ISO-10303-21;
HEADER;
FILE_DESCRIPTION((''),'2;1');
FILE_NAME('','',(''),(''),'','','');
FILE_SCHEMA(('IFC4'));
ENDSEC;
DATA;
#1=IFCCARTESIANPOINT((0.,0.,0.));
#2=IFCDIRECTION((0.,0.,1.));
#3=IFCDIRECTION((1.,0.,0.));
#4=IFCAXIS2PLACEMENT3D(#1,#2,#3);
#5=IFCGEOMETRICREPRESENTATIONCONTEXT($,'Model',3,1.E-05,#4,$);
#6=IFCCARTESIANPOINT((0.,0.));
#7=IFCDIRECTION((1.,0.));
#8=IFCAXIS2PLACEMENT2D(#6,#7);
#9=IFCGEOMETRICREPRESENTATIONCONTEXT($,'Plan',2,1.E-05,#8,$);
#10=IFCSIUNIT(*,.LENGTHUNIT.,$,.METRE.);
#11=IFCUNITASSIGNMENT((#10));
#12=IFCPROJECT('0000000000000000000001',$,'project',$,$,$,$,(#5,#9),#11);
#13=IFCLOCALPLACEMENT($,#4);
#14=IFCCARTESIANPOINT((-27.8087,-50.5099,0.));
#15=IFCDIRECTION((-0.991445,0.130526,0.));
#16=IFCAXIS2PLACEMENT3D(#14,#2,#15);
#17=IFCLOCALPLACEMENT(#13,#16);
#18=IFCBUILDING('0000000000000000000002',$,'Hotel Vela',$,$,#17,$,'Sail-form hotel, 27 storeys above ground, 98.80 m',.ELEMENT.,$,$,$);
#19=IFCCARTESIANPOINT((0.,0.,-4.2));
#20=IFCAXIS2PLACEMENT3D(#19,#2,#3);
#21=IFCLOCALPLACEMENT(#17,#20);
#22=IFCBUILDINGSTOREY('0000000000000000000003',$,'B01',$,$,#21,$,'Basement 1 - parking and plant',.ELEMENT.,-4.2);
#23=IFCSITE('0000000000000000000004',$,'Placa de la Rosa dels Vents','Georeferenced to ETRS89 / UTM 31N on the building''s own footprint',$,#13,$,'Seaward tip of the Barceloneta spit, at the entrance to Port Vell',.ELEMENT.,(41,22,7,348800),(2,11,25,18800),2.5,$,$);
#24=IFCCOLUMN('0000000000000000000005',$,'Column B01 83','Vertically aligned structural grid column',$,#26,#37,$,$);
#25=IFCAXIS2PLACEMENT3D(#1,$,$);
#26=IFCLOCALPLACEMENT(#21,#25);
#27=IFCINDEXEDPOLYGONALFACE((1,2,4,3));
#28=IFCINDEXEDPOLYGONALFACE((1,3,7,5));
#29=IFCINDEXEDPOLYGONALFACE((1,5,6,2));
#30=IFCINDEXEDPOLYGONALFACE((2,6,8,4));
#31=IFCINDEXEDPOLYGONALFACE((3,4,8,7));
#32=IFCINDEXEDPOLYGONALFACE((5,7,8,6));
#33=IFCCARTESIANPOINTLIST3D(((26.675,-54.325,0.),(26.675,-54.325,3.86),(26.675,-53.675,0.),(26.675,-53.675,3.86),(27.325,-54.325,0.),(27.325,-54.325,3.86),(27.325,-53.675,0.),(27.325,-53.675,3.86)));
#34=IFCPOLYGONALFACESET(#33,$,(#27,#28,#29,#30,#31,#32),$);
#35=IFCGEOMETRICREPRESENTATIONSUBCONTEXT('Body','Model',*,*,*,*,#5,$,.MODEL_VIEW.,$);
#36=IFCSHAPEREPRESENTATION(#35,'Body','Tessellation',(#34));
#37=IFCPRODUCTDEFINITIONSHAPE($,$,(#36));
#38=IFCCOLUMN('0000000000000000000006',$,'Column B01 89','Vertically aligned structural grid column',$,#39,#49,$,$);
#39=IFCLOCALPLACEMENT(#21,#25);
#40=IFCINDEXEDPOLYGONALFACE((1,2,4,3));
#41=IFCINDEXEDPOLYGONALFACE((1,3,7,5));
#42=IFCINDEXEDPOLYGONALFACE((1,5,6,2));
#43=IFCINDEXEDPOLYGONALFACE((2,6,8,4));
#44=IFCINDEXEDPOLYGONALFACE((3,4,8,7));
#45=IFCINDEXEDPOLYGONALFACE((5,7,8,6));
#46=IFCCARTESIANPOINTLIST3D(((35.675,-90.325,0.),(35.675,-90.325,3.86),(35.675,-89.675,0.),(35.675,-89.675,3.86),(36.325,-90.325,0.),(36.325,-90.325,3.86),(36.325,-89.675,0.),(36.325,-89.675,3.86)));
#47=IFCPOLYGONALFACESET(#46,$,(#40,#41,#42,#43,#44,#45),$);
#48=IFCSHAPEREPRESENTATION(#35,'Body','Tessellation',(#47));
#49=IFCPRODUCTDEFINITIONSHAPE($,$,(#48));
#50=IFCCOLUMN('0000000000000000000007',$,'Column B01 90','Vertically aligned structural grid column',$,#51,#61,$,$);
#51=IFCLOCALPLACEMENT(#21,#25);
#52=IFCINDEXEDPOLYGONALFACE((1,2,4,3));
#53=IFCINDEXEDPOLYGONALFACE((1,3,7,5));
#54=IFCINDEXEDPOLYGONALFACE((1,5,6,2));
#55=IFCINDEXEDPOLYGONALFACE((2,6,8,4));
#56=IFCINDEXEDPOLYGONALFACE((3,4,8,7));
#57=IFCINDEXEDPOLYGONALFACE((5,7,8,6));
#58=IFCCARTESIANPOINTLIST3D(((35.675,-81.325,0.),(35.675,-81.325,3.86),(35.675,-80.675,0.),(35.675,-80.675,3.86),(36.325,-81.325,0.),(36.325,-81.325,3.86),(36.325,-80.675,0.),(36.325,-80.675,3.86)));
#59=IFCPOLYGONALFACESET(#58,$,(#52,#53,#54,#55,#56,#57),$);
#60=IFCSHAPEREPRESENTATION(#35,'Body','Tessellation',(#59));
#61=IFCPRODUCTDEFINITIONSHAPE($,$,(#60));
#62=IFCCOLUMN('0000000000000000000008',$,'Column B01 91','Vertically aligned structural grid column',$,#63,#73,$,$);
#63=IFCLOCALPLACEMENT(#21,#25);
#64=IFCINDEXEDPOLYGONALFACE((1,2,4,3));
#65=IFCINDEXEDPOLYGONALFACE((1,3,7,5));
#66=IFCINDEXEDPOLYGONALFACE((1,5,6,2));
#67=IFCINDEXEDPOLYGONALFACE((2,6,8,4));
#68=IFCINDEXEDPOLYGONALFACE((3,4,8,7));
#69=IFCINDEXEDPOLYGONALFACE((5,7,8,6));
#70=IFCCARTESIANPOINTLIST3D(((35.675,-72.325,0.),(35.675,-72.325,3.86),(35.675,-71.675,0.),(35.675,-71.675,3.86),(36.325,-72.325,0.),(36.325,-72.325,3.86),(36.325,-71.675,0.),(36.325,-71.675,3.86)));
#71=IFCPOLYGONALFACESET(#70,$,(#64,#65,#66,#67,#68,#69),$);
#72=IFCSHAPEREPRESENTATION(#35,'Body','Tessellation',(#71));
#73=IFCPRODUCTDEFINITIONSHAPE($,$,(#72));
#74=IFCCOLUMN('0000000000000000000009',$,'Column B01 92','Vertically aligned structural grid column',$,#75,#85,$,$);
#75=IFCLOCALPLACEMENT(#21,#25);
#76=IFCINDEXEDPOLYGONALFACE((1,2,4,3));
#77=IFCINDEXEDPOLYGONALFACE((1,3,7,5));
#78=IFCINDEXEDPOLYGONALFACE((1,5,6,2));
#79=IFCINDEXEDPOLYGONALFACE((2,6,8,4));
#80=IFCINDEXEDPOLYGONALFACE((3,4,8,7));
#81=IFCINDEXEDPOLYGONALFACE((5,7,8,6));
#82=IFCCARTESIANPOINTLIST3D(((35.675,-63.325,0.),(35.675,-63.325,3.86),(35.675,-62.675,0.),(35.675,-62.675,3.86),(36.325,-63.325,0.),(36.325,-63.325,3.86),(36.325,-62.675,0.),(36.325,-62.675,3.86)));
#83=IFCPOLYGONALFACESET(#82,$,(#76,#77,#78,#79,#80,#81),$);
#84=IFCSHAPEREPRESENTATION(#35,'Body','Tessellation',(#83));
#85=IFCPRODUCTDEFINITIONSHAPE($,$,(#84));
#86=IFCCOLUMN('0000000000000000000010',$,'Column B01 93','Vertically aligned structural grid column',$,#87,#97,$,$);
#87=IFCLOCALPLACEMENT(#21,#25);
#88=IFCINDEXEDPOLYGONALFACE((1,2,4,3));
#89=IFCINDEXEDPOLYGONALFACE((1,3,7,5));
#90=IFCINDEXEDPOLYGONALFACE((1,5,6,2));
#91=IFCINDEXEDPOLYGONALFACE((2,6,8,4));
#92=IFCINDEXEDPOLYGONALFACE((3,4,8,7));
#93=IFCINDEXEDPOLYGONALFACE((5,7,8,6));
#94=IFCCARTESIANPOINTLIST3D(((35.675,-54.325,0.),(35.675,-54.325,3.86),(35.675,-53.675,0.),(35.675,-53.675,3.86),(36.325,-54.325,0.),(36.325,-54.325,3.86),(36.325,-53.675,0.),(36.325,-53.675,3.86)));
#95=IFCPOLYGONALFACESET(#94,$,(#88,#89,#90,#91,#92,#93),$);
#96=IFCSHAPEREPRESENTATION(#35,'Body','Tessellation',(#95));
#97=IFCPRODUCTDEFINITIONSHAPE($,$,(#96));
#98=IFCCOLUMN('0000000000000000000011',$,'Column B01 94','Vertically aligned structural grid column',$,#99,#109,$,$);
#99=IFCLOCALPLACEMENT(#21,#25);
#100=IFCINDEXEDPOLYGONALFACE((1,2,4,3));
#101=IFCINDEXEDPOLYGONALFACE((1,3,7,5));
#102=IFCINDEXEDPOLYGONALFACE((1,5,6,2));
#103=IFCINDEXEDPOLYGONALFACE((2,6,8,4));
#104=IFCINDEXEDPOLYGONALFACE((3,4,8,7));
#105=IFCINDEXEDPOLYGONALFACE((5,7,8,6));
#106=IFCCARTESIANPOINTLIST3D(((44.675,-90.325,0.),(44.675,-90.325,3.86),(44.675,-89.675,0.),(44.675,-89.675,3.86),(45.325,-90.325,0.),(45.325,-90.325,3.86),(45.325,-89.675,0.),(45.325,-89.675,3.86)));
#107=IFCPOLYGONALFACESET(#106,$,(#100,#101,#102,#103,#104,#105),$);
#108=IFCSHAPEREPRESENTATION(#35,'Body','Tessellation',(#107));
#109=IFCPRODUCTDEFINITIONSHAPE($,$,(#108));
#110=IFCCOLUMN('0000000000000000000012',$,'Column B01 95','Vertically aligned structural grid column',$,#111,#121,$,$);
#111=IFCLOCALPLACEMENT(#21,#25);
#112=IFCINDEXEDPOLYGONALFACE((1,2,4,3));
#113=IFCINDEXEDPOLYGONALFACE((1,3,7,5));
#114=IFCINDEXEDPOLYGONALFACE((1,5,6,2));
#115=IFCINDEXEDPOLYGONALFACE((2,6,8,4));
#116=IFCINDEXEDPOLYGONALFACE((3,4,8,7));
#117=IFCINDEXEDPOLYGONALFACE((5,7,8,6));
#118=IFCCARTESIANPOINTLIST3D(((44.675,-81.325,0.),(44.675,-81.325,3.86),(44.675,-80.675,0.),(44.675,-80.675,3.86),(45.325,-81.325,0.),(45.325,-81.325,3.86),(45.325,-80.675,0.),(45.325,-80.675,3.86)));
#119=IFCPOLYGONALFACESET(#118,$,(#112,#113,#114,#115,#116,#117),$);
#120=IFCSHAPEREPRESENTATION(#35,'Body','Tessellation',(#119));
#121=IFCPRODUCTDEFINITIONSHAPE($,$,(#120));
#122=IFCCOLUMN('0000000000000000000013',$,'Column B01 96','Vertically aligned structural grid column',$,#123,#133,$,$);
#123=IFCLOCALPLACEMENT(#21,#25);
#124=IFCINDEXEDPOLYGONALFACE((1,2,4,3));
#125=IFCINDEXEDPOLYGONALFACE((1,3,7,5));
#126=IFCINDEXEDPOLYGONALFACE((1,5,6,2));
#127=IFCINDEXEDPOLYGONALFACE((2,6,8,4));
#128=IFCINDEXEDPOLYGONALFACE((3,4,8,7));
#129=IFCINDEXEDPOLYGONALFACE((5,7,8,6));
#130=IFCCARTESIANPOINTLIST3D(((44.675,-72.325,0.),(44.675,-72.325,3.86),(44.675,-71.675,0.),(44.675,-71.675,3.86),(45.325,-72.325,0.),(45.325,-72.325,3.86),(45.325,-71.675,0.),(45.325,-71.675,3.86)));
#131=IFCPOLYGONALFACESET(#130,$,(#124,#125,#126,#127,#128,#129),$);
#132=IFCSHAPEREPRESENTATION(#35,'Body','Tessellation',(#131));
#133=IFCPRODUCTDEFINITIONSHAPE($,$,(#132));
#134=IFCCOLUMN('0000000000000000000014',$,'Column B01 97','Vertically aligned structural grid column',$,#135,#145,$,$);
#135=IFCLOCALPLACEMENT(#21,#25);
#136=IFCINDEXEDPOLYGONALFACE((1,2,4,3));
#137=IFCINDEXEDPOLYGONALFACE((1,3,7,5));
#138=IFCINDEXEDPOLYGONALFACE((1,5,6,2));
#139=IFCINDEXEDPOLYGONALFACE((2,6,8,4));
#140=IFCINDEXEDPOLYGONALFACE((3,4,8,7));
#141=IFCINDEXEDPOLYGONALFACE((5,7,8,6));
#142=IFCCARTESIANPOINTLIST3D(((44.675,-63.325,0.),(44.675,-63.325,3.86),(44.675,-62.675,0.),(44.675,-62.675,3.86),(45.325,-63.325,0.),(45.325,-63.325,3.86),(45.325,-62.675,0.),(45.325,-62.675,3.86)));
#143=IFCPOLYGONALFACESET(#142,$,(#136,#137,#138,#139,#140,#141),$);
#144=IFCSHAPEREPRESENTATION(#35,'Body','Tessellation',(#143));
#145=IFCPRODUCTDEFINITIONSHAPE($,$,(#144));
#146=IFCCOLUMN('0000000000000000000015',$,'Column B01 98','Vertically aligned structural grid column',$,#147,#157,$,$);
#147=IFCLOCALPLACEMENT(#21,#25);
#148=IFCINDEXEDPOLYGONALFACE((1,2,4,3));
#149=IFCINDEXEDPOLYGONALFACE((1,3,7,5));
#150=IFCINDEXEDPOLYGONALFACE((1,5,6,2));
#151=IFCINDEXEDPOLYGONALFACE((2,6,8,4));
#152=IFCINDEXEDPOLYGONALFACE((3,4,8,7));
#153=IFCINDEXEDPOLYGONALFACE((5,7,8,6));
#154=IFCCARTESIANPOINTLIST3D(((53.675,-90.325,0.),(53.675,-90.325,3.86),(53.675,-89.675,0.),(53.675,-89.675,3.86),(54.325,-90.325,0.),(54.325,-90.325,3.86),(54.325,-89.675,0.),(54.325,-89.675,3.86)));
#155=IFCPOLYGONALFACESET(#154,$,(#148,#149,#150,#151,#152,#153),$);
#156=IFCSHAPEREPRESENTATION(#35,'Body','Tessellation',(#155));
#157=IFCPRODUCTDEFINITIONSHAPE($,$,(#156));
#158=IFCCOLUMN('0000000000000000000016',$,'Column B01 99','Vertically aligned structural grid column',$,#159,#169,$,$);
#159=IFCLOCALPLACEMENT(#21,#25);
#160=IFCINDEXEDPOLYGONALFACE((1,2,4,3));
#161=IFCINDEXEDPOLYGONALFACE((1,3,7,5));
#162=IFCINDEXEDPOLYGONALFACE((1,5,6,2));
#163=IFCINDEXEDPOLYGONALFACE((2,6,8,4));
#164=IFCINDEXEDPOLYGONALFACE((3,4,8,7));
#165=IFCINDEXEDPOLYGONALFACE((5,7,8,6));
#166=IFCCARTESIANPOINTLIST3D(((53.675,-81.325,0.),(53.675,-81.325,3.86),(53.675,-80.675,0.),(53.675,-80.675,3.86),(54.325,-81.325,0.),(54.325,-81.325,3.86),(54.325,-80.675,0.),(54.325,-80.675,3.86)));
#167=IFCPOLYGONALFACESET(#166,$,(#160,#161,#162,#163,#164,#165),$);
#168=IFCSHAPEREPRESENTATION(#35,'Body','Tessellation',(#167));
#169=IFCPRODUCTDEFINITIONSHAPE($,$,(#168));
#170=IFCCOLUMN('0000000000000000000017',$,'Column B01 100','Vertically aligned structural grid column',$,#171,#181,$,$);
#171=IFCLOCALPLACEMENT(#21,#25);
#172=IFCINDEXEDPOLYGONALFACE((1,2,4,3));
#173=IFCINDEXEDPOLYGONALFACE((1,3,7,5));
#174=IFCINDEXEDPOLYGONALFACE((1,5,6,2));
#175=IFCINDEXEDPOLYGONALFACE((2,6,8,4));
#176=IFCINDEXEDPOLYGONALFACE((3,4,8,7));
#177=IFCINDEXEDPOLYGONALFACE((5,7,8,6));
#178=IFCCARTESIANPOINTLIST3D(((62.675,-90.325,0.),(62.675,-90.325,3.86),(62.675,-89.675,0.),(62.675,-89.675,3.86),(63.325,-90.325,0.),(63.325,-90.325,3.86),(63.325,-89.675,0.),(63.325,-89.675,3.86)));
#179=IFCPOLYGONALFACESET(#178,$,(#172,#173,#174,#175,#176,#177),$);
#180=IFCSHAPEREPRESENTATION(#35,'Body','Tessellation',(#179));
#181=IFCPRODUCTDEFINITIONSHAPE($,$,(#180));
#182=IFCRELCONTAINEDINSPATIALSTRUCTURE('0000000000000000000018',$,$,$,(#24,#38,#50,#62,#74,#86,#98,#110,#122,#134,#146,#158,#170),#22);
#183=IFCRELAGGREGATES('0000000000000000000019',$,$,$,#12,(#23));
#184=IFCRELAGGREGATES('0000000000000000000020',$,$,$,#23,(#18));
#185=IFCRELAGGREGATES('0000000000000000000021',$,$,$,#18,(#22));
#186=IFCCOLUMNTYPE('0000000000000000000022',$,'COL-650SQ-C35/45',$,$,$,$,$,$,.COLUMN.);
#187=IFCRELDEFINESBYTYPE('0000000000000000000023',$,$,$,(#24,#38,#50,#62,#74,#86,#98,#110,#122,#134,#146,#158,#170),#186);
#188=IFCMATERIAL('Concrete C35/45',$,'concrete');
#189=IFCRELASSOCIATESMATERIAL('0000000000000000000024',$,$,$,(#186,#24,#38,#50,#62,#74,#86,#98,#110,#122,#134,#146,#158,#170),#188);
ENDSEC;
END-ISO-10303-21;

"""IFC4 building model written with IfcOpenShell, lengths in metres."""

from ifc_helpers import new_model, si_unit, frame, origin_with_axes, origin_2d_with_axis, place, context, subcontext, project, spatial, line, indexed_curve, rectangle, outline, extrude, material, material_profile, profile_set, profile_usage, type_object, element, save


model = new_model("IFC4")

# Units and contexts
model_context = context("Model", 3, precision=1e-05, world=origin_with_axes())
plan_context = context("Plan", 2, precision=1e-05, world=origin_2d_with_axis())
body_context = subcontext(model_context, "Body", "Model", "MODEL_VIEW")
ifc_project = project(units=[si_unit("LENGTHUNIT", "METRE")], contexts=[model_context, plan_context])

# Site, building, storey
site_placement = place(None, origin_with_axes())
site = spatial("IfcSite", under=ifc_project, at=site_placement, Name="Placa de la Rosa dels Vents", Description="Georeferenced to ETRS89 / UTM 31N on the building's own footprint", LongName="Seaward tip of the Barceloneta spit, at the entrance to Port Vell", CompositionType="ELEMENT", RefLatitude=(41, 22, 7, 348800), RefLongitude=(2, 11, 25, 18800), RefElevation=2.5)
building_placement = place(site_placement, frame((-27.8087, -50.5099, 0.0), z_axis=(0.0, 0.0, 1.0), x_axis=(-0.991445, 0.130526, 0.0)))
building = spatial("IfcBuilding", under=site, at=building_placement, Name="Hotel Vela", LongName="Sail-form hotel, 27 storeys above ground, 98.80 m", CompositionType="ELEMENT")
storey_placement = place(building_placement, frame((0.0, 0.0, -4.2), z_axis=(0.0, 0.0, 1.0), x_axis=(1.0, 0.0, 0.0)))
storey = spatial("IfcBuildingStorey", under=building, at=storey_placement, Name="B01", LongName="Basement 1 - parking and plant", CompositionType="ELEMENT", Elevation=-4.2)

# Columns
ifc_material = material(Name="Concrete C35/45", Category="concrete")
ifc_material_profile = material_profile(ifc_material, rectangle(XDim=0.65, YDim=0.65))
ifc_profile_set = profile_set([ifc_material_profile], Name="COL-650SQ-C35/45")
column_type = type_object("IfcColumnType", Name="COL-650SQ-C35/45", PredefinedType="COLUMN", material=ifc_profile_set)
ifc_profile_usage_1 = profile_usage(ifc_profile_set)
column_1_placement = place(storey_placement, frame((26.675, -54.325, 0.0), z_axis=(0.0, 0.0, 1.0), x_axis=(1.0, 0.0, 0.0)))
element("IfcColumn", 1, at=column_1_placement, inside=storey, type_object=column_type, material=ifc_profile_usage_1, Name="Column B01 83", Description="Vertically aligned structural grid column", context=body_context, shape_type="SweptSolid", body=[
    extrude(outline(indexed_curve([(0.0, 0.0), (0.65, 0.0), (0.65, 0.65), (0.0, 0.65)], segments=[line(1, 2, 3, 4, 1)])), origin_with_axes(), (0.0, 0.0, 1.0), 3.86),
])
ifc_profile_usage_2 = profile_usage(ifc_profile_set)
column_2_placement = place(storey_placement, frame((35.675, -90.325, 0.0), z_axis=(0.0, 0.0, 1.0), x_axis=(1.0, 0.0, 0.0)))
element("IfcColumn", 2, at=column_2_placement, inside=storey, type_object=column_type, material=ifc_profile_usage_2, Name="Column B01 89", Description="Vertically aligned structural grid column", context=body_context, shape_type="SweptSolid", body=[
    extrude(outline(indexed_curve([(0.0, 0.0), (0.65, 0.0), (0.65, 0.65), (0.0, 0.65)], segments=[line(1, 2, 3, 4, 1)])), origin_with_axes(), (0.0, 0.0, 1.0), 3.86),
])
ifc_profile_usage_3 = profile_usage(ifc_profile_set)
column_3_placement = place(storey_placement, frame((35.675, -81.325, 0.0), z_axis=(0.0, 0.0, 1.0), x_axis=(1.0, 0.0, 0.0)))
element("IfcColumn", 3, at=column_3_placement, inside=storey, type_object=column_type, material=ifc_profile_usage_3, Name="Column B01 90", Description="Vertically aligned structural grid column", context=body_context, shape_type="SweptSolid", body=[
    extrude(outline(indexed_curve([(0.0, 0.0), (0.65, 0.0), (0.65, 0.65), (0.0, 0.65)], segments=[line(1, 2, 3, 4, 1)])), origin_with_axes(), (0.0, 0.0, 1.0), 3.86),
])
ifc_profile_usage_4 = profile_usage(ifc_profile_set)
column_4_placement = place(storey_placement, frame((35.675, -72.325, 0.0), z_axis=(0.0, 0.0, 1.0), x_axis=(1.0, 0.0, 0.0)))
element("IfcColumn", 4, at=column_4_placement, inside=storey, type_object=column_type, material=ifc_profile_usage_4, Name="Column B01 91", Description="Vertically aligned structural grid column", context=body_context, shape_type="SweptSolid", body=[
    extrude(outline(indexed_curve([(0.0, 0.0), (0.65, 0.0), (0.65, 0.65), (0.0, 0.65)], segments=[line(1, 2, 3, 4, 1)])), origin_with_axes(), (0.0, 0.0, 1.0), 3.86),
])
ifc_profile_usage_5 = profile_usage(ifc_profile_set)
column_5_placement = place(storey_placement, frame((35.675, -63.325, 0.0), z_axis=(0.0, 0.0, 1.0), x_axis=(1.0, 0.0, 0.0)))
element("IfcColumn", 5, at=column_5_placement, inside=storey, type_object=column_type, material=ifc_profile_usage_5, Name="Column B01 92", Description="Vertically aligned structural grid column", context=body_context, shape_type="SweptSolid", body=[
    extrude(outline(indexed_curve([(0.0, 0.0), (0.65, 0.0), (0.65, 0.65), (0.0, 0.65)], segments=[line(1, 2, 3, 4, 1)])), origin_with_axes(), (0.0, 0.0, 1.0), 3.86),
])
ifc_profile_usage_6 = profile_usage(ifc_profile_set)
column_6_placement = place(storey_placement, frame((35.675, -54.325, 0.0), z_axis=(0.0, 0.0, 1.0), x_axis=(1.0, 0.0, 0.0)))
element("IfcColumn", 6, at=column_6_placement, inside=storey, type_object=column_type, material=ifc_profile_usage_6, Name="Column B01 93", Description="Vertically aligned structural grid column", context=body_context, shape_type="SweptSolid", body=[
    extrude(outline(indexed_curve([(0.0, 0.0), (0.65, 0.0), (0.65, 0.65), (0.0, 0.65)], segments=[line(1, 2, 3, 4, 1)])), origin_with_axes(), (0.0, 0.0, 1.0), 3.86),
])
ifc_profile_usage_7 = profile_usage(ifc_profile_set)
column_7_placement = place(storey_placement, frame((44.675, -90.325, 0.0), z_axis=(0.0, 0.0, 1.0), x_axis=(1.0, 0.0, 0.0)))
element("IfcColumn", 7, at=column_7_placement, inside=storey, type_object=column_type, material=ifc_profile_usage_7, Name="Column B01 94", Description="Vertically aligned structural grid column", context=body_context, shape_type="SweptSolid", body=[
    extrude(outline(indexed_curve([(0.0, 0.0), (0.65, 0.0), (0.65, 0.65), (0.0, 0.65)], segments=[line(1, 2, 3, 4, 1)])), origin_with_axes(), (0.0, 0.0, 1.0), 3.86),
])
ifc_profile_usage_8 = profile_usage(ifc_profile_set)
column_8_placement = place(storey_placement, frame((44.675, -81.325, 0.0), z_axis=(0.0, 0.0, 1.0), x_axis=(1.0, 0.0, 0.0)))
element("IfcColumn", 8, at=column_8_placement, inside=storey, type_object=column_type, material=ifc_profile_usage_8, Name="Column B01 95", Description="Vertically aligned structural grid column", context=body_context, shape_type="SweptSolid", body=[
    extrude(outline(indexed_curve([(0.0, 0.0), (0.65, 0.0), (0.65, 0.65), (0.0, 0.65)], segments=[line(1, 2, 3, 4, 1)])), origin_with_axes(), (0.0, 0.0, 1.0), 3.86),
])
ifc_profile_usage_9 = profile_usage(ifc_profile_set)
column_9_placement = place(storey_placement, frame((44.675, -72.325, 0.0), z_axis=(0.0, 0.0, 1.0), x_axis=(1.0, 0.0, 0.0)))
element("IfcColumn", 9, at=column_9_placement, inside=storey, type_object=column_type, material=ifc_profile_usage_9, Name="Column B01 96", Description="Vertically aligned structural grid column", context=body_context, shape_type="SweptSolid", body=[
    extrude(outline(indexed_curve([(0.0, 0.0), (0.65, 0.0), (0.65, 0.65), (0.0, 0.65)], segments=[line(1, 2, 3, 4, 1)])), origin_with_axes(), (0.0, 0.0, 1.0), 3.86),
])
ifc_profile_usage_10 = profile_usage(ifc_profile_set)
column_10_placement = place(storey_placement, frame((44.675, -63.325, 0.0), z_axis=(0.0, 0.0, 1.0), x_axis=(1.0, 0.0, 0.0)))
element("IfcColumn", 10, at=column_10_placement, inside=storey, type_object=column_type, material=ifc_profile_usage_10, Name="Column B01 97", Description="Vertically aligned structural grid column", context=body_context, shape_type="SweptSolid", body=[
    extrude(outline(indexed_curve([(0.0, 0.0), (0.65, 0.0), (0.65, 0.65), (0.0, 0.65)], segments=[line(1, 2, 3, 4, 1)])), origin_with_axes(), (0.0, 0.0, 1.0), 3.86),
])
ifc_profile_usage_11 = profile_usage(ifc_profile_set)
column_11_placement = place(storey_placement, frame((53.675, -90.325, 0.0), z_axis=(0.0, 0.0, 1.0), x_axis=(1.0, 0.0, 0.0)))
element("IfcColumn", 11, at=column_11_placement, inside=storey, type_object=column_type, material=ifc_profile_usage_11, Name="Column B01 98", Description="Vertically aligned structural grid column", context=body_context, shape_type="SweptSolid", body=[
    extrude(outline(indexed_curve([(0.0, 0.0), (0.65, 0.0), (0.65, 0.65), (0.0, 0.65)], segments=[line(1, 2, 3, 4, 1)])), origin_with_axes(), (0.0, 0.0, 1.0), 3.86),
])
ifc_profile_usage_12 = profile_usage(ifc_profile_set)
column_12_placement = place(storey_placement, frame((53.675, -81.325, 0.0), z_axis=(0.0, 0.0, 1.0), x_axis=(1.0, 0.0, 0.0)))
element("IfcColumn", 12, at=column_12_placement, inside=storey, type_object=column_type, material=ifc_profile_usage_12, Name="Column B01 99", Description="Vertically aligned structural grid column", context=body_context, shape_type="SweptSolid", body=[
    extrude(outline(indexed_curve([(0.0, 0.0), (0.65, 0.0), (0.65, 0.65), (0.0, 0.65)], segments=[line(1, 2, 3, 4, 1)])), origin_with_axes(), (0.0, 0.0, 1.0), 3.86),
])
ifc_profile_usage_13 = profile_usage(ifc_profile_set)
column_13_placement = place(storey_placement, frame((62.675, -90.325, 0.0), z_axis=(0.0, 0.0, 1.0), x_axis=(1.0, 0.0, 0.0)))
element("IfcColumn", 13, at=column_13_placement, inside=storey, type_object=column_type, material=ifc_profile_usage_13, Name="Column B01 100", Description="Vertically aligned structural grid column", context=body_context, shape_type="SweptSolid", body=[
    extrude(outline(indexed_curve([(0.0, 0.0), (0.65, 0.0), (0.65, 0.65), (0.0, 0.65)], segments=[line(1, 2, 3, 4, 1)])), origin_with_axes(), (0.0, 0.0, 1.0), 3.86),
])

save(model, "model.ifc")
